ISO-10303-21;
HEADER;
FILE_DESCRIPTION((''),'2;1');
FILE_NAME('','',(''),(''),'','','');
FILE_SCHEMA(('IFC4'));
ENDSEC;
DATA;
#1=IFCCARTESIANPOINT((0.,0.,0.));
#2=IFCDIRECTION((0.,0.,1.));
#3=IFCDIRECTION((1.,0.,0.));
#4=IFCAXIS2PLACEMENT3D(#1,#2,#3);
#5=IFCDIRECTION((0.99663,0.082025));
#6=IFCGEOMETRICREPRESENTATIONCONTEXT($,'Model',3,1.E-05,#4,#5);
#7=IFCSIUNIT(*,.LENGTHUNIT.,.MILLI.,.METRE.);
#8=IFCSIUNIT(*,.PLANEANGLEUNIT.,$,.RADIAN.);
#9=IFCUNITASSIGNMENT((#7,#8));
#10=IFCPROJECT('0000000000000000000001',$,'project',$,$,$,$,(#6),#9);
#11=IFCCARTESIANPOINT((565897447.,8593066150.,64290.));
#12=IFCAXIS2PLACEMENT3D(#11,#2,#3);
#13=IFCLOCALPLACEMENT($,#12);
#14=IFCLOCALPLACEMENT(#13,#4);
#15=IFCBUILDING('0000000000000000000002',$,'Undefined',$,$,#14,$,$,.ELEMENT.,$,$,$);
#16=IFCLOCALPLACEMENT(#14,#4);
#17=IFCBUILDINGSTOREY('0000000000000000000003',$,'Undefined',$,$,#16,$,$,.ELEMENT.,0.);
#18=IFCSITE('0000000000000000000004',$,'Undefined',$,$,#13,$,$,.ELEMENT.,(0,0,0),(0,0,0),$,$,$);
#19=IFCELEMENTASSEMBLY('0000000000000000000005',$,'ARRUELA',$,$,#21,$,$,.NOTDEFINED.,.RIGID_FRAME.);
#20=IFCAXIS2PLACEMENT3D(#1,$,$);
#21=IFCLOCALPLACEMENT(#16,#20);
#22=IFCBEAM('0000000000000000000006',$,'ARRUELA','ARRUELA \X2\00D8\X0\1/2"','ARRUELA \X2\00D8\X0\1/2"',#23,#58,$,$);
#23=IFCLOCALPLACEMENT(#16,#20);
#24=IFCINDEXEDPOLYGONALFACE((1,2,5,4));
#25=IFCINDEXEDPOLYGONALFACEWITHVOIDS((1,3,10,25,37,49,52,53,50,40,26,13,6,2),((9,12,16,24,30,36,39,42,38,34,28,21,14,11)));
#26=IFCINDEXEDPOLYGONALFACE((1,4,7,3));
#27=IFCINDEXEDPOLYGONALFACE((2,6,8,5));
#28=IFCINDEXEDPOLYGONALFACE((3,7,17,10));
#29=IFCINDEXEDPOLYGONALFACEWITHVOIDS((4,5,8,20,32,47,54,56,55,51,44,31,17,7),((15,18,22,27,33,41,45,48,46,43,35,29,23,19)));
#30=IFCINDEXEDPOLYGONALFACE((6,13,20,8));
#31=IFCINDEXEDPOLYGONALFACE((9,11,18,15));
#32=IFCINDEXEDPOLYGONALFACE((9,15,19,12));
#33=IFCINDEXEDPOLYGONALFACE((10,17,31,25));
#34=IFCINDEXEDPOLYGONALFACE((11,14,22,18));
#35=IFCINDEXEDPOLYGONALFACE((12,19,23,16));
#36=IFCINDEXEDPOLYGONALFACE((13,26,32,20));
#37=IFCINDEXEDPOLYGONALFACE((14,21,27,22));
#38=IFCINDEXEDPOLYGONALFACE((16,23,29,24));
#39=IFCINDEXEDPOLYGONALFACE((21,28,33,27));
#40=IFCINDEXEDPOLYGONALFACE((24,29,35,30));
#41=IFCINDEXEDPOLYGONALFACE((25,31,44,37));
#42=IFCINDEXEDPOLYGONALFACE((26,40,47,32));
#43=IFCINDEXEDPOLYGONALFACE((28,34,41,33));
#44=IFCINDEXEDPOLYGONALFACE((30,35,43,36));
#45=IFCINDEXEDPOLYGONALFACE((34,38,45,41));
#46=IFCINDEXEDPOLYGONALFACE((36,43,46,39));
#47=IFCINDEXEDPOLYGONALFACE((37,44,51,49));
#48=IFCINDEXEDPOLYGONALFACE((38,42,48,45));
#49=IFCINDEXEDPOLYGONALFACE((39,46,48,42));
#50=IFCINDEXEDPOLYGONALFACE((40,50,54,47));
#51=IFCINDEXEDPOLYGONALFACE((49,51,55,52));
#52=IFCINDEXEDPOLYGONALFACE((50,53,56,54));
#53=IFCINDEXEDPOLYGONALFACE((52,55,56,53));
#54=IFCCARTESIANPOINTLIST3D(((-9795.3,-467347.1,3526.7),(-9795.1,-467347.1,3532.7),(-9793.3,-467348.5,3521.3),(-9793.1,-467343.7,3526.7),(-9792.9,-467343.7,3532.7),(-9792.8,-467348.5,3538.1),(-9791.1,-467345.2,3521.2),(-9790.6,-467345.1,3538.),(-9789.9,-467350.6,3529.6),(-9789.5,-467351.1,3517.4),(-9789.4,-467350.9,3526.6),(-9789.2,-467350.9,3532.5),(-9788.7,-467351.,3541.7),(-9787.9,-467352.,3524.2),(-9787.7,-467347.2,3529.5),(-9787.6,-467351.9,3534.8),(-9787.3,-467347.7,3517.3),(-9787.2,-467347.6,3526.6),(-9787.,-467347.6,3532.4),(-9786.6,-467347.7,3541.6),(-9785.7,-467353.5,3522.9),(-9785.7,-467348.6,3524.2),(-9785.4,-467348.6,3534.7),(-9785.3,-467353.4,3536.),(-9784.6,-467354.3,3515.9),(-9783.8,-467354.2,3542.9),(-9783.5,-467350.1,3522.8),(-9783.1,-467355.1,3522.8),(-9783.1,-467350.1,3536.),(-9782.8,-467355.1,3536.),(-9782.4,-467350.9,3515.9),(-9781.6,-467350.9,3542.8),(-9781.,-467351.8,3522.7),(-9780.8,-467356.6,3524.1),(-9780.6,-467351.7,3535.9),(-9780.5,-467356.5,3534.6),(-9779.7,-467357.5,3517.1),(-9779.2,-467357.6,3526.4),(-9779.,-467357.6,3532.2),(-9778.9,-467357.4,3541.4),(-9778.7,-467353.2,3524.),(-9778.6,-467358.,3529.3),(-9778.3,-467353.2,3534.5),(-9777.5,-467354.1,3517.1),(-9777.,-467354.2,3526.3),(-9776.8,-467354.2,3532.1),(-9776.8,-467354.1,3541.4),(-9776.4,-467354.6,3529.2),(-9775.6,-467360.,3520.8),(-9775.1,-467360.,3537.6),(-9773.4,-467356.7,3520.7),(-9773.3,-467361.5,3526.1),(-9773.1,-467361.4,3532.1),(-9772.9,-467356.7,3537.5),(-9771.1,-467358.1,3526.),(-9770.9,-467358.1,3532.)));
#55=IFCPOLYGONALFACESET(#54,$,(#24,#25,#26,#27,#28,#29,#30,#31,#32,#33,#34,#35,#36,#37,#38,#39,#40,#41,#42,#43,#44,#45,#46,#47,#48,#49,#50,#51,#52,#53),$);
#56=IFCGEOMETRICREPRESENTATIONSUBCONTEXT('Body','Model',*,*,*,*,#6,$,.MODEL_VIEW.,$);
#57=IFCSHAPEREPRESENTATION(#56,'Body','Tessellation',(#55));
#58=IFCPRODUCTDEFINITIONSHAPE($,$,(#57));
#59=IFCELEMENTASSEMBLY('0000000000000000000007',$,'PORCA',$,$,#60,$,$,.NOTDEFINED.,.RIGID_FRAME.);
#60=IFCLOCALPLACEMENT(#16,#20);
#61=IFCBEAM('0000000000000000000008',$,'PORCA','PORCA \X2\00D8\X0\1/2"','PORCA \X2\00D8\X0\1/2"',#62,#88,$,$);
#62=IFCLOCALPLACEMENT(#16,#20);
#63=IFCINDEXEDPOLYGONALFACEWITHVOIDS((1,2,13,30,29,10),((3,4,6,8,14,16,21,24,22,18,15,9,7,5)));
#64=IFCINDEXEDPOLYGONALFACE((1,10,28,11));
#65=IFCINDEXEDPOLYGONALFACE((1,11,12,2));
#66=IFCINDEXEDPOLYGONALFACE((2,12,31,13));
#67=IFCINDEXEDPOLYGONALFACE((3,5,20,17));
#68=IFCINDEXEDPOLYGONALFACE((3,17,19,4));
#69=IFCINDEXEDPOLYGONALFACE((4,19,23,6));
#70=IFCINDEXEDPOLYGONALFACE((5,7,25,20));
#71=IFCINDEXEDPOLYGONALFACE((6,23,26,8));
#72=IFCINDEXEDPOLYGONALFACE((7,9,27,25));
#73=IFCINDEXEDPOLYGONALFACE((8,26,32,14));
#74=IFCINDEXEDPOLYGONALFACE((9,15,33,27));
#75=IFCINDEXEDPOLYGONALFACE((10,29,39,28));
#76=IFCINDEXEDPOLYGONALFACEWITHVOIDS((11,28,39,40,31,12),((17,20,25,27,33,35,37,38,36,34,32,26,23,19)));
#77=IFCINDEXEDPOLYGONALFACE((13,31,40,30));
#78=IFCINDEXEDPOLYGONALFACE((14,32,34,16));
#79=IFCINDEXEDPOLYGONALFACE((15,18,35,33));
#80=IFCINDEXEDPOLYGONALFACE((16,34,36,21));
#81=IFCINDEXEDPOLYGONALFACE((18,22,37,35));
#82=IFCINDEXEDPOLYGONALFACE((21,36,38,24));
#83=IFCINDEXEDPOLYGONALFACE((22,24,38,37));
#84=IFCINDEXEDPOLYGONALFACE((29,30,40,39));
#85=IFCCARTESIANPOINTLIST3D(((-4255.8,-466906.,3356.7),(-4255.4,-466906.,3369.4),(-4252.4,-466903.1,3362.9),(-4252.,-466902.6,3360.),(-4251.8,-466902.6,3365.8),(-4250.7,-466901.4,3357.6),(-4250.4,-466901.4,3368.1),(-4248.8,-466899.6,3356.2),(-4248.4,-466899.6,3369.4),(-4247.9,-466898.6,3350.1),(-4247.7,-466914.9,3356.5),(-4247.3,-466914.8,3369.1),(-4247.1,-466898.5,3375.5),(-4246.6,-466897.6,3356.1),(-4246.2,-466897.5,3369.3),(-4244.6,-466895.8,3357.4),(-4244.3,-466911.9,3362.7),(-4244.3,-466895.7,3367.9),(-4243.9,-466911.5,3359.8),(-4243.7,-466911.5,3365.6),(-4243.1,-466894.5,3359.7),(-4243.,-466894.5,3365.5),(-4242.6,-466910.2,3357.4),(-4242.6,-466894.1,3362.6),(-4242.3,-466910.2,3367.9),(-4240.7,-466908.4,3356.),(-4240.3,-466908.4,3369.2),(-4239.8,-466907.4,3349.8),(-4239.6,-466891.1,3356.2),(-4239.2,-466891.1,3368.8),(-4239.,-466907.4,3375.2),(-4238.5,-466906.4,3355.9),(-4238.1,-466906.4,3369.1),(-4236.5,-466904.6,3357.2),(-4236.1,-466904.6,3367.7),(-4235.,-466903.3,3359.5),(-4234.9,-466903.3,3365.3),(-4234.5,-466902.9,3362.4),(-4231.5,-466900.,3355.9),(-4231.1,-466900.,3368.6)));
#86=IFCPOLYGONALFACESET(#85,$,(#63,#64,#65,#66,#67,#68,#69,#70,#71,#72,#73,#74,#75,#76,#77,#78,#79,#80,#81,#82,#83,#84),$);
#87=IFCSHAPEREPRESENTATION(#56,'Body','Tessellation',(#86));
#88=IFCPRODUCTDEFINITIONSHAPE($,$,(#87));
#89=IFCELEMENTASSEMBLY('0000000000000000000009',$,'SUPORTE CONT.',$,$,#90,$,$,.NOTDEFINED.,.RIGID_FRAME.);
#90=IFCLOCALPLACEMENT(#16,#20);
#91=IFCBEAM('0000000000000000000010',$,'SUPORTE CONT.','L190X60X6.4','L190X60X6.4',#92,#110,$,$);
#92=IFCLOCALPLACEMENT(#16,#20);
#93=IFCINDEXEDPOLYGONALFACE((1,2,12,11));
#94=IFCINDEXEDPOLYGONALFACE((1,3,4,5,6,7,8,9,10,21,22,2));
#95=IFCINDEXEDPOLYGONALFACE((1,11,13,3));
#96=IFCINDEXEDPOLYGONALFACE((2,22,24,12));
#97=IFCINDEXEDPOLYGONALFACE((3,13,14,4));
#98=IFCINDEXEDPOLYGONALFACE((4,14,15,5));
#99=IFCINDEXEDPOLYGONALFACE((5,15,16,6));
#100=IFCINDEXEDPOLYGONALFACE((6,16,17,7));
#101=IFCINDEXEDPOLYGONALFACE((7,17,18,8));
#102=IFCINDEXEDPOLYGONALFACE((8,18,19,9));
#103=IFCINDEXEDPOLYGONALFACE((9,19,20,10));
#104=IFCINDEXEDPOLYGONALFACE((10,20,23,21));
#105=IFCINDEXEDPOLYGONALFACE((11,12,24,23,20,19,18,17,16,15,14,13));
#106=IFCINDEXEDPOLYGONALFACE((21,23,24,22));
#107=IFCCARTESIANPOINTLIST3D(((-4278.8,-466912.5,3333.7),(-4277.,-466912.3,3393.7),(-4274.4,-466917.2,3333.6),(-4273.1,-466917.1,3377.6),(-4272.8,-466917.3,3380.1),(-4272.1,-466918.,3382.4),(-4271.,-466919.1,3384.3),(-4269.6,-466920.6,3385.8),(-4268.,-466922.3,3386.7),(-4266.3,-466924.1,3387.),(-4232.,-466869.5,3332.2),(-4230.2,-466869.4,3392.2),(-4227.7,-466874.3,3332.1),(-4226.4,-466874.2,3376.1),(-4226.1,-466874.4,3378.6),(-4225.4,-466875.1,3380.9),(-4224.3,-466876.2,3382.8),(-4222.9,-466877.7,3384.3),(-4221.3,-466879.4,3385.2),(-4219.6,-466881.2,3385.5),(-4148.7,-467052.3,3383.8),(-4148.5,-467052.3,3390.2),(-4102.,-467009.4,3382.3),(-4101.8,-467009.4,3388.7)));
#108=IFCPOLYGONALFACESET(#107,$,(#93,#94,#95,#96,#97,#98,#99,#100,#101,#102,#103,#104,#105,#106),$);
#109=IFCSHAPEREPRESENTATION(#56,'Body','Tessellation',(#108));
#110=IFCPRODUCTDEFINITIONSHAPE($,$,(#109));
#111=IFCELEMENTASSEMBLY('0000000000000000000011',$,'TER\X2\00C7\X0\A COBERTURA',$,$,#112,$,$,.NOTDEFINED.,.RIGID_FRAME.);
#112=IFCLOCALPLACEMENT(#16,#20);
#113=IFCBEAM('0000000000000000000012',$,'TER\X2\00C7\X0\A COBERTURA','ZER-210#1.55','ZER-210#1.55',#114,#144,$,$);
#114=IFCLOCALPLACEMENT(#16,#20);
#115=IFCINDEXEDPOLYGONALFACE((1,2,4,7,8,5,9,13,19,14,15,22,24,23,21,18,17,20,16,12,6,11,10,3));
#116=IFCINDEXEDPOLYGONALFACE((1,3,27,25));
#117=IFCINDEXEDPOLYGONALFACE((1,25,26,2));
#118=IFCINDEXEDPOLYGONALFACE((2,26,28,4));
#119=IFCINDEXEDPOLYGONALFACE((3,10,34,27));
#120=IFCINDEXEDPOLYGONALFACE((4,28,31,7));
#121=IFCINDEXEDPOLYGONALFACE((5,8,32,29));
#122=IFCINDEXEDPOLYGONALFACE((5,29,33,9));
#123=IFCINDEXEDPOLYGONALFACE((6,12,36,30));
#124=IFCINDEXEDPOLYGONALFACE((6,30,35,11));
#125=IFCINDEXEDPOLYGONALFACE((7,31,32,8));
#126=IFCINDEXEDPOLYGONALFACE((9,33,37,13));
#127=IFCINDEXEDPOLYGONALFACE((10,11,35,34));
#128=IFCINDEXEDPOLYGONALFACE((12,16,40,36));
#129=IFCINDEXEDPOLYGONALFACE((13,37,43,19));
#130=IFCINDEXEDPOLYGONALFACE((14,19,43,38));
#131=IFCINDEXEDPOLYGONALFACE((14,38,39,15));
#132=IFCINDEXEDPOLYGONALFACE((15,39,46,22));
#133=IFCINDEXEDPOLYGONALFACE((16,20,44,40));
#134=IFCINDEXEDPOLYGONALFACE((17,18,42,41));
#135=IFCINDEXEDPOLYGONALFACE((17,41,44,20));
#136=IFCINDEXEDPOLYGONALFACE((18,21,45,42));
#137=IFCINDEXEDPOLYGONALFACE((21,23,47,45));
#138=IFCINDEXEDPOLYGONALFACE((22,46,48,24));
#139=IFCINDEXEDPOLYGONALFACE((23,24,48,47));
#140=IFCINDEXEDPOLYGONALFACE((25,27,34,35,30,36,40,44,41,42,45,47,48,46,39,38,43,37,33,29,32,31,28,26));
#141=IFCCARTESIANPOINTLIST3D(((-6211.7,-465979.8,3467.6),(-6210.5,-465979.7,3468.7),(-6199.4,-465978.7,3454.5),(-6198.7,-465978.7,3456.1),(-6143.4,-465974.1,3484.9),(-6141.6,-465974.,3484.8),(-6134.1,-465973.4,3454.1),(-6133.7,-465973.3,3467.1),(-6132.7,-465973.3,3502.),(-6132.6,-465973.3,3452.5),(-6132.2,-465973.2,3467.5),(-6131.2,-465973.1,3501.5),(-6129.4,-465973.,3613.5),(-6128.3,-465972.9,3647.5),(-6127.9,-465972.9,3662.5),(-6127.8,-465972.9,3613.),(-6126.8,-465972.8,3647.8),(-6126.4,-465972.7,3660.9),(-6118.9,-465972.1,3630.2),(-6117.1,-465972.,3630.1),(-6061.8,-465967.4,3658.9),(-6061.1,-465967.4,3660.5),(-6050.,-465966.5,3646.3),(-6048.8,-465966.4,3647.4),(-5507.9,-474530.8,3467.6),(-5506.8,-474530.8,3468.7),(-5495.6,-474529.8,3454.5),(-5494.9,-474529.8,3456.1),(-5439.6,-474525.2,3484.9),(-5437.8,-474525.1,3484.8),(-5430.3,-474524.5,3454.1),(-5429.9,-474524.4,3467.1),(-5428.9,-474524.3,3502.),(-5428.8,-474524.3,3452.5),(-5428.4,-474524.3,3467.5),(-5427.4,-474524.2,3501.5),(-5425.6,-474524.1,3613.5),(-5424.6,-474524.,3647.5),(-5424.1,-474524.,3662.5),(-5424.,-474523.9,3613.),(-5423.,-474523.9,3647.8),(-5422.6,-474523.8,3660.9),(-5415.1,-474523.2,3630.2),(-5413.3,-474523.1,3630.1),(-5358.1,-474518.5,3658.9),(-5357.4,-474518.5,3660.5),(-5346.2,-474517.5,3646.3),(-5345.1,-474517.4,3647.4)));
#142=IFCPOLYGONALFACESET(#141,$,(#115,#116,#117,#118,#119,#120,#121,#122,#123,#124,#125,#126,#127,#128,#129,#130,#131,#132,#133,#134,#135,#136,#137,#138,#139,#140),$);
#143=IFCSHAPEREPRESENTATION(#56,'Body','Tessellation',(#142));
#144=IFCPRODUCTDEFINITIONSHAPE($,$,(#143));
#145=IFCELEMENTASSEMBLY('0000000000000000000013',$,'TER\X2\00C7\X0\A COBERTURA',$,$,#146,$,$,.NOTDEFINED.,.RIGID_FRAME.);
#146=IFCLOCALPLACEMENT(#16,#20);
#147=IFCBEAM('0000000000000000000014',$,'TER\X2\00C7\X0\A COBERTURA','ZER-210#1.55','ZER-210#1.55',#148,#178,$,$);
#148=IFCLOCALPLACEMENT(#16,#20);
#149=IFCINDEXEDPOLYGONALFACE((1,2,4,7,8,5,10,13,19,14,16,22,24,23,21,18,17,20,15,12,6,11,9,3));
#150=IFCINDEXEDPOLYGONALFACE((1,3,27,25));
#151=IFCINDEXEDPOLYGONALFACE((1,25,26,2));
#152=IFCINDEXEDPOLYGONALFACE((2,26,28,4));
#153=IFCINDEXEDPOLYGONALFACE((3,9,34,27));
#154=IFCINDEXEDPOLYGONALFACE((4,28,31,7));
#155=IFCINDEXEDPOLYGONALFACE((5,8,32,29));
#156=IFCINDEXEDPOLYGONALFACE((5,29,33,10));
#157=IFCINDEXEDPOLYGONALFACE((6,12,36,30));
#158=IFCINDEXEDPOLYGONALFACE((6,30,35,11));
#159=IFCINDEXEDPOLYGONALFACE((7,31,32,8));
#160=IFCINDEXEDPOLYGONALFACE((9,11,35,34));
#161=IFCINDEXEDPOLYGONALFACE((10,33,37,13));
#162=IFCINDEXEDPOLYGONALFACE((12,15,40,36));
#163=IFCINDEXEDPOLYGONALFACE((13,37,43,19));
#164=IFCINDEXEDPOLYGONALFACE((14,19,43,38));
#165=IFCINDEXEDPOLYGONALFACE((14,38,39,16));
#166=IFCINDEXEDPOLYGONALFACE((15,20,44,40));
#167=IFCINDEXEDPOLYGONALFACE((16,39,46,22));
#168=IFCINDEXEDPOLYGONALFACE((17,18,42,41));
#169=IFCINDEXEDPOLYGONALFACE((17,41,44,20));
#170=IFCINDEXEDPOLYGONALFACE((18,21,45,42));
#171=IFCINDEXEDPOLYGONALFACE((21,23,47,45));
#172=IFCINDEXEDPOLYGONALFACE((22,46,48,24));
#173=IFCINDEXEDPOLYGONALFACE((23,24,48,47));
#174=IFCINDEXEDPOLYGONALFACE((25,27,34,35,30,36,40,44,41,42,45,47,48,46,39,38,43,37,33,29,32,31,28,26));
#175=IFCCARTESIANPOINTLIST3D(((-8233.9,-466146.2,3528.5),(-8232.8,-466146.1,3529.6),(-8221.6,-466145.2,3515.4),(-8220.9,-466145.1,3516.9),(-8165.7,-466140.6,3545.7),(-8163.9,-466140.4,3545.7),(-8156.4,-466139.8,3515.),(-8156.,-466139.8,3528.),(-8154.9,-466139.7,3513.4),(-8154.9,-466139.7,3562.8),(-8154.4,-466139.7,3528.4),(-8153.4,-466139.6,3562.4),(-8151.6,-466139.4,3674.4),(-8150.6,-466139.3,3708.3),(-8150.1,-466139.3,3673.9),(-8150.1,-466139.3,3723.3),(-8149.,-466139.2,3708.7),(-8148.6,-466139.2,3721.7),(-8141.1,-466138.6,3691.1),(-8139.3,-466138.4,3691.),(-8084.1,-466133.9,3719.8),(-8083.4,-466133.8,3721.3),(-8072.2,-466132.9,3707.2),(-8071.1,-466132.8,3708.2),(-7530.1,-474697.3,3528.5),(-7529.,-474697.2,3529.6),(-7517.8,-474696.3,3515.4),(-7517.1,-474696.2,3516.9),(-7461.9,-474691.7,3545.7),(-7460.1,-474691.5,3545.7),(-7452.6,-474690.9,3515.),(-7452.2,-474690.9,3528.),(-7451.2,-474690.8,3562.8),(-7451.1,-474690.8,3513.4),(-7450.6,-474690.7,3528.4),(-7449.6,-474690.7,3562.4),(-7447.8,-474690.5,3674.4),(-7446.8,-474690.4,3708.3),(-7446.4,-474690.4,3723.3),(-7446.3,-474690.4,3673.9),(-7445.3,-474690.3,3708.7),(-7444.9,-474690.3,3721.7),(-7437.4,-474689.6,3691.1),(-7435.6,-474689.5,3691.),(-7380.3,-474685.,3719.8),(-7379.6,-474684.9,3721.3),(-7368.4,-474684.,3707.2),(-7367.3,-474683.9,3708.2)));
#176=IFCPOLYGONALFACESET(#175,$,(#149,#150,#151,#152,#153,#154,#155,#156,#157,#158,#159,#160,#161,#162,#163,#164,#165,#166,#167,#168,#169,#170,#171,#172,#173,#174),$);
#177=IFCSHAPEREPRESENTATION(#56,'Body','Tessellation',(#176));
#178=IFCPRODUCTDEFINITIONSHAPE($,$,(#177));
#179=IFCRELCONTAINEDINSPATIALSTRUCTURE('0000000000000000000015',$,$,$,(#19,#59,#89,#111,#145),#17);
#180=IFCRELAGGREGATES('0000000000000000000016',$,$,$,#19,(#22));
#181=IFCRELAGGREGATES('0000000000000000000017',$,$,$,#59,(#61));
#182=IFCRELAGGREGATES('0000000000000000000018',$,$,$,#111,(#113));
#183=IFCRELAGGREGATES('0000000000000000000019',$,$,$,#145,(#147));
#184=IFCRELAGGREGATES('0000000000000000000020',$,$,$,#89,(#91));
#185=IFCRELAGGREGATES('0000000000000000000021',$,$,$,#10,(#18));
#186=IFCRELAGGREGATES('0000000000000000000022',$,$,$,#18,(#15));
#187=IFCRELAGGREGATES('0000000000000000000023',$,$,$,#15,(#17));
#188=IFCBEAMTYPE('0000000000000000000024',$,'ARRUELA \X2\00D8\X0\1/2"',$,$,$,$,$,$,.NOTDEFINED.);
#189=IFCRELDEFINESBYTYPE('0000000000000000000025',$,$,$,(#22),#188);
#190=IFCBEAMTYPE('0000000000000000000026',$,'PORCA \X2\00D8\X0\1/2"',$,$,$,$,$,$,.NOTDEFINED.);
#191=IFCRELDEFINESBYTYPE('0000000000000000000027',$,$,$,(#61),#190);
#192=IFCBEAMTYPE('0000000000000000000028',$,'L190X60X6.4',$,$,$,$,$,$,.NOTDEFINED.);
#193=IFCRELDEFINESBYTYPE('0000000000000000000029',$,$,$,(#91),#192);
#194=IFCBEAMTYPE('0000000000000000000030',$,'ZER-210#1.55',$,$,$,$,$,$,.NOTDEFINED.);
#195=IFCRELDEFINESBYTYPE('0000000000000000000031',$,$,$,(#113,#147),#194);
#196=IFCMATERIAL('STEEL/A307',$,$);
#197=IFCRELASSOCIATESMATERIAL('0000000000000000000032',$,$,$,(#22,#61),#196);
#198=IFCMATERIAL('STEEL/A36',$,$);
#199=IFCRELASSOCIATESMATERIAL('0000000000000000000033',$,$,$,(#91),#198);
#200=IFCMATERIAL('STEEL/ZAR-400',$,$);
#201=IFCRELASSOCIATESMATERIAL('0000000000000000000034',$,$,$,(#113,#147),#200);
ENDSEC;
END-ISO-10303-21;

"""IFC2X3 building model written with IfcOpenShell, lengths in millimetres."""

from ifc_helpers import new_model, si_unit, direction, frame, origin_with_axes, origin_2d_with_axis, place, context, subcontext, project, spatial, polyline, l_section, outline, extrude, material, type_object, element, aggregate, save


model = new_model("IFC2X3")

# Units and contexts
model_context = context("Model", 3, precision=1e-05, world=origin_with_axes(), true_north=direction((0.99663, 0.082025)))
body_context = subcontext(model_context, "Body", "Model", "MODEL_VIEW")
ifc_project = project(units=[si_unit("LENGTHUNIT", "METRE", prefix="MILLI"), si_unit("PLANEANGLEUNIT", "RADIAN")], contexts=[model_context])

# Site, building, storey
site_placement = place(None, frame((565897447.0, 8593066150.0, 64290.0), z_axis=(0.0, 0.0, 1.0), x_axis=(1.0, 0.0, 0.0)))
site = spatial("IfcSite", under=ifc_project, at=site_placement, Name="Undefined", CompositionType="ELEMENT", RefLatitude=(0, 0, 0), RefLongitude=(0, 0, 0))
building_placement = place(site_placement, origin_with_axes())
building = spatial("IfcBuilding", under=site, at=building_placement, Name="Undefined", CompositionType="ELEMENT")
storey_placement = place(building_placement, origin_with_axes())
storey = spatial("IfcBuildingStorey", under=building, at=storey_placement, Name="Undefined", CompositionType="ELEMENT", Elevation=0.0)

# Element assemblies, beams
ifc_material_1 = material(Name="STEEL/A36")
ifc_material_2 = material(Name="STEEL/A307")
beam_type_1 = type_object("IfcBeamType", Name="ARRUELA Ø1/2\"", PredefinedType="NOTDEFINED")
assembly_1_placement = place(storey_placement, origin_with_axes())
assembly_1 = element("IfcElementAssembly", 1, at=assembly_1_placement, inside=storey, Name="ARRUELA", AssemblyPlace="NOTDEFINED", PredefinedType="RIGID_FRAME")
beam_1_placement = place(assembly_1_placement, frame((-9784.2, -467354.3, 3529.4), z_axis=(-0.836984, 0.546715, 0.02368), x_axis=(0.546411, 0.837315, -0.018398)))
beam_1 = element("IfcBeam", 2, at=beam_1_placement, type_object=beam_type_1, material=ifc_material_2, Name="ARRUELA", Description="ARRUELA Ø1/2\"", ObjectType="ARRUELA Ø1/2\"", context=body_context, shape_type="SweptSolid", body=[
    extrude(outline(polyline([(-12.2, 5.9), (-8.4, 10.5), (-3.0, 13.2), (3.0, 13.2), (8.4, 10.5), (12.2, 5.9), (13.5, 0.0), (12.2, -5.9), (8.4, -10.5), (3.0, -13.2), (-3.0, -13.2), (-8.4, -10.5), (-12.2, -5.9), (-13.5, 0.0), (-12.2, 5.9)]), holes=[polyline([(5.3, 4.2), (2.9, 6.1), (0.0, 6.8), (-2.9, 6.1), (-5.3, 4.2), (-6.6, 1.5), (-6.6, -1.5), (-5.3, -4.2), (-2.9, -6.1), (0.0, -6.7), (2.9, -6.1), (5.3, -4.2), (6.6, -1.5), (6.6, 1.5), (5.3, 4.2)])]), frame((4.0, 0.0, 0.0), z_axis=(-1.0, 0.0, 0.0), x_axis=(0.0, -1.0, 0.0)), (0.0, 0.0, 1.0), 4.0),
])
aggregate(assembly_1, [beam_1])
assembly_2_placement = place(storey_placement, origin_with_axes())
assembly_2 = element("IfcElementAssembly", 3, at=assembly_2_placement, inside=storey, Name="PORCA", AssemblyPlace="NOTDEFINED", PredefinedType="RIGID_FRAME")
beam_type_2 = type_object("IfcBeamType", Name="PORCA Ø1/2\"", PredefinedType="NOTDEFINED")
beam_2_placement = place(assembly_2_placement, frame((-4239.4, -466907.4, 3362.5), z_axis=(-0.736334, -0.676203, 0.02368), x_axis=(-0.675958, 0.736711, 0.018398)))
beam_2 = element("IfcBeam", 4, at=beam_2_placement, type_object=beam_type_2, material=ifc_material_2, Name="PORCA", Description="PORCA Ø1/2\"", ObjectType="PORCA Ø1/2\"", context=body_context, shape_type="SweptSolid", body=[
    extrude(outline(polyline([(-6.3, -11.0), (-12.7, 0.0), (-6.3, 11.0), (6.3, 11.0), (12.7, 0.0), (6.3, -11.0), (-6.3, -11.0)]), holes=[polyline([(5.3, 4.2), (2.9, 6.0), (0.0, 6.7), (-2.9, 6.0), (-5.3, 4.2), (-6.6, 1.5), (-6.6, -1.5), (-5.3, -4.2), (-2.9, -6.0), (0.0, -6.7), (2.9, -6.0), (5.3, -4.2), (6.6, -1.5), (6.6, 1.5), (5.3, 4.2)])]), frame((12.0, 0.0, 0.0), z_axis=(-1.0, 0.0, 0.0), x_axis=(0.0, -1.0, 0.0)), (0.0, 0.0, 1.0), 12.0),
])
aggregate(assembly_2, [beam_2])
assembly_3_placement = place(storey_placement, origin_with_axes())
assembly_3 = element("IfcElementAssembly", 5, at=assembly_3_placement, inside=storey, Name="SUPORTE CONT.", AssemblyPlace="NOTDEFINED", PredefinedType="RIGID_FRAME")
beam_type_3 = type_object("IfcBeamType", Name="L190X60X6.4", PredefinedType="NOTDEFINED")
beam_3_placement = place(assembly_3_placement, frame((-4213.7, -466982.4, 3362.0), z_axis=(0.675958, -0.736711, -0.018398), x_axis=(0.736334, 0.676203, -0.02368)))
beam_3 = element("IfcBeam", 6, at=beam_3_placement, type_object=beam_type_3, material=ifc_material_1, Name="SUPORTE CONT.", Description="L190X60X6.4", ObjectType="L190X60X6.4", context=body_context, shape_type="SweptSolid", body=[
    extrude(l_section(Depth=190.0, Width=60.0, Thickness=6.4, FilletRadius=9.6, at=origin_2d_with_axis()), frame((63.5, 0.0, 0.0), z_axis=(-1.0, 0.0, 0.0), x_axis=(0.0, -1.0, 0.0)), (0.0, 0.0, 1.0), 63.5),
])
assembly_4_placement = place(storey_placement, origin_with_axes())
assembly_4 = element("IfcElementAssembly", 7, at=assembly_4_placement, inside=storey, Name="TERÇA COBERTURA", AssemblyPlace="NOTDEFINED", PredefinedType="RIGID_FRAME")
ifc_material_3 = material(Name="STEEL/ZAR-400")
beam_type_4 = type_object("IfcBeamType", Name="ZER-210#1.55", PredefinedType="NOTDEFINED")
beam_4_placement = place(assembly_4_placement, frame((-6130.3, -465973.1, 3557.5), z_axis=(0.029885, 0.00246, 0.99955), x_axis=(0.082025, -0.99663, 0.0)))
beam_4 = element("IfcBeam", 8, at=beam_4_placement, type_object=beam_type_4, material=ifc_material_3, Name="TERÇA COBERTURA", Description="ZER-210#1.55", ObjectType="ZER-210#1.55", context=body_context, shape_type="SweptSolid", body=[
    extrude(outline(polyline([(-65.6, 103.4), (-77.9, 91.2), (-79.0, 92.3), (-66.2, 105.0), (0.8, 105.0), (0.8, 90.0), (-9.2, 73.0), (0.8, 56.0), (0.8, -55.6), (11.0, -73.0), (0.8, -90.4), (0.8, -103.5), (65.6, -103.4), (77.9, -91.2), (79.0, -92.3), (66.2, -105.0), (-0.8, -105.0), (-0.8, -90.0), (9.2, -73.0), (-0.8, -56.0), (-0.8, 55.6), (-11.0, 73.0), (-0.8, 90.4), (-0.8, 103.5), (-65.6, 103.4)])), frame((8580.0, 0.0, 0.0), z_axis=(-1.0, 0.0, 0.0), x_axis=(0.0, -1.0, 0.0)), (0.0, 0.0, 1.0), 8580.0),
])
aggregate(assembly_4, [beam_4])
assembly_5_placement = place(storey_placement, origin_with_axes())
assembly_5 = element("IfcElementAssembly", 9, at=assembly_5_placement, inside=storey, Name="TERÇA COBERTURA", AssemblyPlace="NOTDEFINED", PredefinedType="RIGID_FRAME")
beam_5_placement = place(assembly_5_placement, frame((-8152.5, -466139.5, 3618.4), z_axis=(0.029885, 0.00246, 0.99955), x_axis=(0.082025, -0.99663, 0.0)))
beam_5 = element("IfcBeam", 10, at=beam_5_placement, type_object=beam_type_4, material=ifc_material_3, Name="TERÇA COBERTURA", Description="ZER-210#1.55", ObjectType="ZER-210#1.55", context=body_context, shape_type="SweptSolid", body=[
    extrude(outline(polyline([(-65.6, 103.4), (-77.9, 91.2), (-79.0, 92.3), (-66.2, 105.0), (0.8, 105.0), (0.8, 90.0), (-9.2, 73.0), (0.8, 56.0), (0.8, -55.6), (11.0, -73.0), (0.8, -90.4), (0.8, -103.5), (65.6, -103.4), (77.9, -91.2), (79.0, -92.3), (66.2, -105.0), (-0.8, -105.0), (-0.8, -90.0), (9.2, -73.0), (-0.8, -56.0), (-0.8, 55.6), (-11.0, 73.0), (-0.8, 90.4), (-0.8, 103.5), (-65.6, 103.4)])), frame((8580.0, 0.0, 0.0), z_axis=(-1.0, 0.0, 0.0), x_axis=(0.0, -1.0, 0.0)), (0.0, 0.0, 1.0), 8580.0),
])
aggregate(assembly_5, [beam_5])

aggregate(assembly_3, [beam_3])

save(model, "model.ifc")
